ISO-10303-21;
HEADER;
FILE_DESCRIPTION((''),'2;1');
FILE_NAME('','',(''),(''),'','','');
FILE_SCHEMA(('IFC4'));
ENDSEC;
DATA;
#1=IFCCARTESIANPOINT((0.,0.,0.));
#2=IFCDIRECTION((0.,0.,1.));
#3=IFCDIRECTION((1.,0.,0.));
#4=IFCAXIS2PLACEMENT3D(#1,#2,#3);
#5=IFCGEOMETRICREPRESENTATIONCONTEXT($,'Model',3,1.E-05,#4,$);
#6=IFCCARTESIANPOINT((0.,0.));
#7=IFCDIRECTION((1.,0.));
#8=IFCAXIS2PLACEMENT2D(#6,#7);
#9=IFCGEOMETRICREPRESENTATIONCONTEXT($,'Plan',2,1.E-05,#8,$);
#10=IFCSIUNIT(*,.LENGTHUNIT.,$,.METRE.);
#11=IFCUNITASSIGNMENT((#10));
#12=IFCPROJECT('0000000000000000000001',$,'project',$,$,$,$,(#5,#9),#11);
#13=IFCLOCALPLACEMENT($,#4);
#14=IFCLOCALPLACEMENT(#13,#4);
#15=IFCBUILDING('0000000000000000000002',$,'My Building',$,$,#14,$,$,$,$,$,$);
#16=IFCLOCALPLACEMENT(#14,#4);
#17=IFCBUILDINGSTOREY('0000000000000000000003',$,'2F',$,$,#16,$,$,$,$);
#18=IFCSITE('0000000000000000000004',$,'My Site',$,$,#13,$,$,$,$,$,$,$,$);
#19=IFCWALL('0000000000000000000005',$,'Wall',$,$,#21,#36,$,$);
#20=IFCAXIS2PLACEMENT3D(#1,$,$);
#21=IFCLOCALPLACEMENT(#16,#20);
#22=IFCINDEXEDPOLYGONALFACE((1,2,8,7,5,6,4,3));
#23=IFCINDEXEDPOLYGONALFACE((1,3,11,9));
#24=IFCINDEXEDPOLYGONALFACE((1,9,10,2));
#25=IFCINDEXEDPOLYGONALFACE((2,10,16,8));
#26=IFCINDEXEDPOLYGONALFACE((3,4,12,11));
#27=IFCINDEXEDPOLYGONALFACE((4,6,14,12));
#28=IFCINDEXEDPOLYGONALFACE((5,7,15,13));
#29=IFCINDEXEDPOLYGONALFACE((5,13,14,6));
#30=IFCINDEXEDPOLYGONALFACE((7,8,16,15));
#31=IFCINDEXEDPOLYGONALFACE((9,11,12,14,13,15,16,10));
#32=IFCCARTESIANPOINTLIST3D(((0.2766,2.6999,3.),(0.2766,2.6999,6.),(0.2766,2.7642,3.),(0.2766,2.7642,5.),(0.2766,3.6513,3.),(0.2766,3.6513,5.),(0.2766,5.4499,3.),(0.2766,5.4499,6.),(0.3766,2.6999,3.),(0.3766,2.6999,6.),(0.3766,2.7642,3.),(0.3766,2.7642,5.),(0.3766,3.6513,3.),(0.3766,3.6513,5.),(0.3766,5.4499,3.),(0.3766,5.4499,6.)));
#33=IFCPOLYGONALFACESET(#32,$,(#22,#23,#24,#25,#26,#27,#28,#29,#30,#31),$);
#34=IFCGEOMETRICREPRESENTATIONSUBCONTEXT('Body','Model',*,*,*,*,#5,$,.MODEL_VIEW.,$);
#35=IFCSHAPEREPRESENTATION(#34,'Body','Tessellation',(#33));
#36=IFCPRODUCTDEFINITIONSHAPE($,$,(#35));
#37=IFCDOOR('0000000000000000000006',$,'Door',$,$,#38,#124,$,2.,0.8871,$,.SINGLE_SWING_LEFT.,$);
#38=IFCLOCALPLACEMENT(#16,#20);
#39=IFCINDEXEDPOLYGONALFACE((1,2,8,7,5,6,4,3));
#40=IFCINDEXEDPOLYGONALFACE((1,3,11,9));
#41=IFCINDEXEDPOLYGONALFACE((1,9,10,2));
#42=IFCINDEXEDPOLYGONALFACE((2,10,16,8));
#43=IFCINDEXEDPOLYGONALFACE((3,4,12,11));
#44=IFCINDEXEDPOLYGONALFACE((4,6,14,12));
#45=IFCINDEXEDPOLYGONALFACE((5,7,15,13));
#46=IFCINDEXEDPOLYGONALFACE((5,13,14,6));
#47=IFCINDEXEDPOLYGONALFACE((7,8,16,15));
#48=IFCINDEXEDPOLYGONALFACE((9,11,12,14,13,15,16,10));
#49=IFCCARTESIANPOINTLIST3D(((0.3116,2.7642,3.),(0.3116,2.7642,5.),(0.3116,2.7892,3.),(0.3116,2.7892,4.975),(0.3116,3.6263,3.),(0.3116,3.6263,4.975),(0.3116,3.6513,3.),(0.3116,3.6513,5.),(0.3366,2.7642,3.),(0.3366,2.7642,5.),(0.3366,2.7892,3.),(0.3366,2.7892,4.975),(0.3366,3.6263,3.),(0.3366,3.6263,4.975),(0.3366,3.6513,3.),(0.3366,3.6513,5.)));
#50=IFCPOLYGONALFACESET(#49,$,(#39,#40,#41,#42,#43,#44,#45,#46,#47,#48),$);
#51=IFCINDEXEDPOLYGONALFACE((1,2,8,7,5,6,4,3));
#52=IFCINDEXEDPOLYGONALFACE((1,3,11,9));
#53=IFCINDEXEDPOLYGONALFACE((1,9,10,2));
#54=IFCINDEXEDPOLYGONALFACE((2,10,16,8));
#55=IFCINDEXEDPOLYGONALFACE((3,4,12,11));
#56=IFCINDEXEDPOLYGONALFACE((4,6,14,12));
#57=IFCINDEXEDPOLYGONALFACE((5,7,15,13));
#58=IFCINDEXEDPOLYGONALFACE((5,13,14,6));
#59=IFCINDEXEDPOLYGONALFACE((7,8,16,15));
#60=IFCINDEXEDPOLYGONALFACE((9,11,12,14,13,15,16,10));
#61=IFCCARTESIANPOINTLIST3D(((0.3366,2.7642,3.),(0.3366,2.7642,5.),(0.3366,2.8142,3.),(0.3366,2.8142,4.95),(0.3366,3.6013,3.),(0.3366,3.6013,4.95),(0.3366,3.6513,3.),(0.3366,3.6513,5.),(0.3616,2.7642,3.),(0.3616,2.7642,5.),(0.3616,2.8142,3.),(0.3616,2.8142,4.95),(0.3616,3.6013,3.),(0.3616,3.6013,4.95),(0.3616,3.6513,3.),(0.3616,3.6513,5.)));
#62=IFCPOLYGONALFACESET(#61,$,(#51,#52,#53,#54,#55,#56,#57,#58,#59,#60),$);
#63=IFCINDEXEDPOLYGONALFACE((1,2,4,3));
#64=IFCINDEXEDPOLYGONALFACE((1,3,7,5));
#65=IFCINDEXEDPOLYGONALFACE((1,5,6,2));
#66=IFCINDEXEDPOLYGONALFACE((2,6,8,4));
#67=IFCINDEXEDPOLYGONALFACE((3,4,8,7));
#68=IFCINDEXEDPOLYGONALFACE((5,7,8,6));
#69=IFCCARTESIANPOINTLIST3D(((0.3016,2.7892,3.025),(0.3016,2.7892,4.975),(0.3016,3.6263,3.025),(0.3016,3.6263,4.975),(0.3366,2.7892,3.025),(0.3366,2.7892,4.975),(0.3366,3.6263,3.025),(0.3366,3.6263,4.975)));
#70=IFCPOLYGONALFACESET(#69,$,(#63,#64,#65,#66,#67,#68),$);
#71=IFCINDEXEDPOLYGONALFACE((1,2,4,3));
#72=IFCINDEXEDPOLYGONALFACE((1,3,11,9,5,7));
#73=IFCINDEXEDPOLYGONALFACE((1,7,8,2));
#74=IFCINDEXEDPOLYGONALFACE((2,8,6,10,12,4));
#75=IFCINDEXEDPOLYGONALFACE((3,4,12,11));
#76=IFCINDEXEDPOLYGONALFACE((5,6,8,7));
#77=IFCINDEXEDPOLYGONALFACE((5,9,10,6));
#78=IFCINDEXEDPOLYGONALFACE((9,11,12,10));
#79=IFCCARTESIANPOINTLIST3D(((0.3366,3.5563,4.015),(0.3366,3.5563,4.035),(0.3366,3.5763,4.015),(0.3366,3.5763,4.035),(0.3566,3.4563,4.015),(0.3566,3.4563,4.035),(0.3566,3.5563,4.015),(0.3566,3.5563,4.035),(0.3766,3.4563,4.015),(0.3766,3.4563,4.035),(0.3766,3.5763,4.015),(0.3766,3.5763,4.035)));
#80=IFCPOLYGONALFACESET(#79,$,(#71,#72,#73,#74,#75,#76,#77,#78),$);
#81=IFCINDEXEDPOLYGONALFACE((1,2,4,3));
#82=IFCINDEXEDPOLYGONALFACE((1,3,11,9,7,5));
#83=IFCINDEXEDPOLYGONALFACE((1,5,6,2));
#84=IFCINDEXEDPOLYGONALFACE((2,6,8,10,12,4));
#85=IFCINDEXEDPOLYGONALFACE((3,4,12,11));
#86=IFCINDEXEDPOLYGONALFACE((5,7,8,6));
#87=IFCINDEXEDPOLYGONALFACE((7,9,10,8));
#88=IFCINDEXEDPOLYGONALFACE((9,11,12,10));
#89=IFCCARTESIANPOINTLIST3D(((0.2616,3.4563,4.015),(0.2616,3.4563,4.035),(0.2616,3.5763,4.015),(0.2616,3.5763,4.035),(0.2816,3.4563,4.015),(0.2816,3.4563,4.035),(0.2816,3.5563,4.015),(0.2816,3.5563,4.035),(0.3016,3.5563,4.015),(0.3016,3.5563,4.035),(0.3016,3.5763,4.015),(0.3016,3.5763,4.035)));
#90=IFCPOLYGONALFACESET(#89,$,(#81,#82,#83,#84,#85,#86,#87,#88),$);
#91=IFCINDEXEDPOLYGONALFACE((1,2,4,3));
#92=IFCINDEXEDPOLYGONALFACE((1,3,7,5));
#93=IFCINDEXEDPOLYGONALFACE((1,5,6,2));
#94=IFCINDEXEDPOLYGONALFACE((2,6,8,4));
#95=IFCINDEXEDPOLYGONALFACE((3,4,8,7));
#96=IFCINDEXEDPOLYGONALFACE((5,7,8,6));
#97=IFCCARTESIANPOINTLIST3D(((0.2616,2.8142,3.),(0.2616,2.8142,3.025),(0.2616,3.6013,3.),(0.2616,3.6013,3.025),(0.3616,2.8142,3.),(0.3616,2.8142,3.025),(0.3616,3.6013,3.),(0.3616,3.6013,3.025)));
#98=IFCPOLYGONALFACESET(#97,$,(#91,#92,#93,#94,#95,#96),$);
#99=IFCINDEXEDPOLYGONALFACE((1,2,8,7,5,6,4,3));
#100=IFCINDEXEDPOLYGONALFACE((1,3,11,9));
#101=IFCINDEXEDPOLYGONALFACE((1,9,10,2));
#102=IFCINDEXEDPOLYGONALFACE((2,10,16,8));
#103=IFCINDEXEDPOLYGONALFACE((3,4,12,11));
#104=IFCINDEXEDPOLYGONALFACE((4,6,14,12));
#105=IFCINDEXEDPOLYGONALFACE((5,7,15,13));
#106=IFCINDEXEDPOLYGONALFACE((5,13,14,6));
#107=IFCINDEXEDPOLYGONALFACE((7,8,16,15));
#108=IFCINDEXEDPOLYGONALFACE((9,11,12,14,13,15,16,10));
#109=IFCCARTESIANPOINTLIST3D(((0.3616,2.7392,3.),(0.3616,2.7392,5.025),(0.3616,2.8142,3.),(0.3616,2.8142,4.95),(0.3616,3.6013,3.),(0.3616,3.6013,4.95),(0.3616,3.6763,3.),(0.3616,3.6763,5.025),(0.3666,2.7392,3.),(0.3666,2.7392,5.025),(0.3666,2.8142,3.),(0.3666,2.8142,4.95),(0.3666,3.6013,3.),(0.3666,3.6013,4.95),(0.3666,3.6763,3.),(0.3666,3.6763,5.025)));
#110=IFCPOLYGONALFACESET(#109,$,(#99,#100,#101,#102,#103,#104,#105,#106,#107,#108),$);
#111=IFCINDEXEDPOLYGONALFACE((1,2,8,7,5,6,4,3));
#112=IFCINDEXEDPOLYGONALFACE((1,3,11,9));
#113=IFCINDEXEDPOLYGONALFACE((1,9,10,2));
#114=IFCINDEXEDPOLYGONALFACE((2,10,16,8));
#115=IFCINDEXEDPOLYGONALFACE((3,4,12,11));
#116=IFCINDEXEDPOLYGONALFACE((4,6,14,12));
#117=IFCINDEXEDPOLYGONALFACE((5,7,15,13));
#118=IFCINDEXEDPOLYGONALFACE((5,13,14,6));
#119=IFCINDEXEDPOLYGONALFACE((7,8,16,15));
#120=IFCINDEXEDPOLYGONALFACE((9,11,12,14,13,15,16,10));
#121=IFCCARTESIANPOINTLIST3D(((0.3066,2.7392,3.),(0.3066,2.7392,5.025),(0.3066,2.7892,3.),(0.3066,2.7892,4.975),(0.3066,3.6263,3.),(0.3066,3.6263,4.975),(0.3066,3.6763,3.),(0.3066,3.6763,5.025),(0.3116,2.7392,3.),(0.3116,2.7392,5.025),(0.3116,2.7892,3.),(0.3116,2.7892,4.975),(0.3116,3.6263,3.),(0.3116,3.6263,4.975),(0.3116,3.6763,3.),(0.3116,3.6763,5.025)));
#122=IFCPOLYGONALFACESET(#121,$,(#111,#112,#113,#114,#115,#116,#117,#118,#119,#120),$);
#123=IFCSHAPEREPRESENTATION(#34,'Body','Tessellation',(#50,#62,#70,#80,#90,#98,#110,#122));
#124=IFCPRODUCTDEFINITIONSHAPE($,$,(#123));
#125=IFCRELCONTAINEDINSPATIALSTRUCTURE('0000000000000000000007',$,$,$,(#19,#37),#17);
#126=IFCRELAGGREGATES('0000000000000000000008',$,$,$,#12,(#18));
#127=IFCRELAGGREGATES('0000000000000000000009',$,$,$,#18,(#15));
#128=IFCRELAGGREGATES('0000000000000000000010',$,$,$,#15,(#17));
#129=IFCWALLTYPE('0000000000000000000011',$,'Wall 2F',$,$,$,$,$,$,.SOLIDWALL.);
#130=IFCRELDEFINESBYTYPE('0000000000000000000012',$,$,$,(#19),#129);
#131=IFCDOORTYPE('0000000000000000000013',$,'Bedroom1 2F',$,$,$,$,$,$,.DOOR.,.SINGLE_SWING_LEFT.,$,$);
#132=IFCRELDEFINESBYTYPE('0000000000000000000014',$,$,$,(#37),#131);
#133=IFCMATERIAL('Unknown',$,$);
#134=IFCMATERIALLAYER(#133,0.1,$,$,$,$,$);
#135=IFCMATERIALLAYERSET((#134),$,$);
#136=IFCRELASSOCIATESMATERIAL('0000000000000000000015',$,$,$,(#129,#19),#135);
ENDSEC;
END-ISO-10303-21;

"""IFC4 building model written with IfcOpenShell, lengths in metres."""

from ifc_helpers import new_model, entity, si_unit, frame, origin_with_axes, origin_2d_with_axis, place, context, subcontext, project, spatial, line, indexed_curve, outline, extrude, shape, source, transform, mapped, material, layer, layer_set, layer_usage, type_object, type_shapes, element, fill, save


model = new_model("IFC4")

# Units and contexts
model_context = context("Model", 3, precision=1e-05, world=origin_with_axes())
plan_context = context("Plan", 2, precision=1e-05, world=origin_2d_with_axis())
body_context_1 = subcontext(model_context, "Body", "Model", "MODEL_VIEW")
body_context_2 = subcontext(plan_context, "Body", "Plan", "PLAN_VIEW")
ifc_project = project(units=[si_unit("LENGTHUNIT", "METRE")], contexts=[model_context, plan_context])

# Site, building, storey
site_placement = place(None, origin_with_axes())
site = spatial("IfcSite", under=ifc_project, at=site_placement, Name="My Site")
building_placement = place(site_placement, origin_with_axes())
building = spatial("IfcBuilding", under=site, at=building_placement, Name="My Building")
storey_placement = place(building_placement, origin_with_axes())
storey = spatial("IfcBuildingStorey", under=building, at=storey_placement, Name="2F")

# Shared definitions
ifc_material = material(Name="Unknown")

# Shared definitions
ifc_layer = layer(ifc_material, 0.1)
ifc_layer_set = layer_set([ifc_layer])
wall_type = type_object("IfcWallType", Name="Wall 2F", PredefinedType="SOLIDWALL", material=ifc_layer_set)

# Wall, opening, door
ifc_layer_usage_1 = layer_usage(ifc_layer_set, "AXIS2", "POSITIVE", 0.0)
wall_1_placement = place(storey_placement, frame((0.3766, 2.6999, 3.0), z_axis=(0.0, 0.0, 1.0), x_axis=(0.0, 1.0, 0.0)))
wall_1 = element("IfcWall", 1, at=wall_1_placement, inside=storey, type_object=wall_type, material=ifc_layer_usage_1, Name="Wall", context=body_context_1, shape_type="SweptSolid", body=[
    extrude(outline(indexed_curve([(0.0, 0.0), (0.0, 0.1), (2.75, 0.1), (2.75, 0.0)], segments=[line(1, 2, 3, 4, 1)])), origin_with_axes(), (0.0, 0.0, 1.0), 3.0),
])
shared_shape_1 = source(origin_with_axes(), body_context_1, "Body", "SweptSolid", [
    extrude(outline(indexed_curve([(0.0, 0.0), (0.8871, 0.0), (0.8871, 2.0), (0.0, 2.0)], segments=[line(1, 2, 3, 4, 1)])), frame((0.0, -0.6, 0.0), z_axis=(0.0, -1.0, 0.0), x_axis=(1.0, 0.0, 0.0)), (0.0, 0.0, -1.0), 1.2),
])
opening_1_placement = place(wall_1_placement, frame((0.0644, 0.015, 0.0), z_axis=(0.0, 0.0, 1.0), x_axis=(1.0, 0.0, 0.0)))
opening_1 = element("IfcOpeningElement", 2, at=opening_1_placement, cuts=wall_1, PredefinedType="OPENING", context=body_context_1, shape_type="MappedRepresentation", body=[
    mapped(shared_shape_1, transform((0.0, 0.0, 0.0), x_axis=(1.0, 0.0, 0.0), y_axis=(0.0, 1.0, 0.0), z_axis=(0.0, 0.0, 1.0), scale=1.0)),
])
door_type_1 = type_object("IfcDoorType", Name="Bedroom1 2F", OperationType="SINGLE_SWING_LEFT", PredefinedType="DOOR")
shared_shape_2 = source(origin_with_axes(), body_context_1, "Body", "SweptSolid", [
    extrude(outline(indexed_curve([(0.0, 0.0), (0.0, 2.0), (0.8871, 2.0), (0.8871, 0.0), (0.8621, 0.0), (0.8621, 1.975), (0.025, 1.975), (0.025, 0.0)], segments=[line(1, 2, 3, 4, 5, 6, 7, 8, 1)])), frame((0.0, 0.025, 0.0), z_axis=(0.0, -1.0, 0.0), x_axis=(1.0, 0.0, 0.0)), (0.0, 0.0, -1.0), 0.025),
    extrude(outline(indexed_curve([(0.0, 0.0), (0.0, 2.0), (0.8871, 2.0), (0.8871, 0.0), (0.8371, 0.0), (0.8371, 1.95), (0.05, 1.95), (0.05, 0.0)], segments=[line(1, 2, 3, 4, 5, 6, 7, 8, 1)])), frame((0.0, 0.0, 0.0), z_axis=(0.0, -1.0, 0.0), x_axis=(1.0, 0.0, 0.0)), (0.0, 0.0, -1.0), 0.025),
    extrude(outline(indexed_curve([(0.0, 0.0), (0.8371, 0.0), (0.8371, 0.035), (0.0, 0.035)], segments=[line(1, 2, 3, 4, 1)])), frame((0.025, 0.025, 0.025), z_axis=(0.0, 0.0, 1.0), x_axis=(1.0, 0.0, 0.0)), (0.0, 0.0, 1.0), 1.95),
    extrude(outline(indexed_curve([(0.0, 0.0), (0.0, -0.04), (-0.12, -0.04), (-0.12, -0.02), (-0.02, -0.02), (-0.02, 0.0)], segments=[line(1, 2, 3, 4, 5, 6, 1)])), frame((0.8121, 0.025, 1.015), z_axis=(0.0, 0.0, 1.0), x_axis=(1.0, 0.0, 0.0)), (0.0, 0.0, 1.0), 0.02),
    extrude(outline(indexed_curve([(0.0, 0.0), (0.0, 0.04), (-0.12, 0.04), (-0.12, 0.02), (-0.02, 0.02), (-0.02, 0.0)], segments=[line(1, 2, 3, 4, 5, 6, 1)])), frame((0.8121, 0.06, 1.015), z_axis=(0.0, 0.0, 1.0), x_axis=(1.0, 0.0, 0.0)), (0.0, 0.0, 1.0), 0.02),
    extrude(outline(indexed_curve([(0.0, 0.0), (0.7871, 0.0), (0.7871, 0.1), (0.0, 0.1)], segments=[line(1, 2, 3, 4, 1)])), frame((0.05, 0.0, 0.0), z_axis=(0.0, 0.0, 1.0), x_axis=(1.0, 0.0, 0.0)), (0.0, 0.0, 1.0), 0.025),
    extrude(outline(indexed_curve([(0.0, 0.0), (0.0, 2.025), (0.9371, 2.025), (0.9371, 0.0), (0.8621, 0.0), (0.8621, 1.95), (0.075, 1.95), (0.075, 0.0)], segments=[line(1, 2, 3, 4, 5, 6, 7, 8, 1)])), frame((-0.025, -0.005, 0.0), z_axis=(0.0, -1.0, 0.0), x_axis=(1.0, 0.0, 0.0)), (0.0, 0.0, -1.0), 0.005),
    extrude(outline(indexed_curve([(0.0, 0.0), (0.0, 2.025), (0.9371, 2.025), (0.9371, 0.0), (0.8871, 0.0), (0.8871, 1.975), (0.05, 1.975), (0.05, 0.0)], segments=[line(1, 2, 3, 4, 5, 6, 7, 8, 1)])), frame((-0.025, 0.05, 0.0), z_axis=(0.0, -1.0, 0.0), x_axis=(1.0, 0.0, 0.0)), (0.0, 0.0, -1.0), 0.005),
])
shared_shape_3 = source(origin_with_axes(), body_context_2, "Body", "Curve2D", [
    entity("IfcIndexedPolyCurve", entity("IfcCartesianPointList2D", [[0.0, 0.0], [0.0, 0.05], [0.025, 0.05], [0.025, 0.025], [0.05, 0.025], [0.05, 0.0]]), [entity("IfcLineIndex", [1, 2, 3, 4, 5, 6, 1])]),
    entity("IfcIndexedPolyCurve", entity("IfcCartesianPointList2D", [[0.8871, 0.0], [0.8871, 0.05], [0.8621, 0.05], [0.8621, 0.025], [0.8371, 0.025], [0.8371, 0.0]]), [entity("IfcLineIndex", [1, 2, 3, 4, 5, 6, 1])]),
    entity("IfcTrimmedCurve", entity("IfcEllipse", entity("IfcAxis2Placement2D", entity("IfcCartesianPoint", [0.06, 0.05]), entity("IfcDirection", [1.0, 0.0])), 0.8021, 0.8371), [entity("IfcCartesianPoint", [0.8621, 0.05])], [entity("IfcCartesianPoint", [0.06, 0.8871])], True, "CARTESIAN"),
    entity("IfcIndexedPolyCurve", entity("IfcCartesianPointList2D", [[0.025, 0.05], [0.06, 0.05], [0.06, 0.8871], [0.025, 0.8871]]), [entity("IfcLineIndex", [1, 2, 3, 4, 1])]),
])
type_shapes(door_type_1, [shared_shape_2, shared_shape_3])
door_1_placement = place(opening_1_placement, frame((0.0, 0.0, 0.0), z_axis=(0.0, 0.0, 1.0), x_axis=(1.0, 0.0, 0.0)))
door_1 = element("IfcDoor", 3, at=door_1_placement, inside=storey, type_object=door_type_1, Name="Door", OperationType="SINGLE_SWING_LEFT", OverallHeight=2.0, OverallWidth=0.8871, shapes=[
    shape(body_context_1, "Body", "MappedRepresentation", [mapped(shared_shape_2, transform((0.0, 0.0, 0.0), x_axis=(1.0, 0.0, 0.0), y_axis=(0.0, 1.0, 0.0), z_axis=(0.0, 0.0, 1.0), scale=1.0))]),
    shape(body_context_2, "Body", "MappedRepresentation", [mapped(shared_shape_3, transform((0.0, 0.0, 0.0), x_axis=(1.0, 0.0, 0.0), y_axis=(0.0, 1.0, 0.0), z_axis=(0.0, 0.0, 1.0), scale=1.0))]),
])
fill(opening_1, door_1)

save(model, "model.ifc")
